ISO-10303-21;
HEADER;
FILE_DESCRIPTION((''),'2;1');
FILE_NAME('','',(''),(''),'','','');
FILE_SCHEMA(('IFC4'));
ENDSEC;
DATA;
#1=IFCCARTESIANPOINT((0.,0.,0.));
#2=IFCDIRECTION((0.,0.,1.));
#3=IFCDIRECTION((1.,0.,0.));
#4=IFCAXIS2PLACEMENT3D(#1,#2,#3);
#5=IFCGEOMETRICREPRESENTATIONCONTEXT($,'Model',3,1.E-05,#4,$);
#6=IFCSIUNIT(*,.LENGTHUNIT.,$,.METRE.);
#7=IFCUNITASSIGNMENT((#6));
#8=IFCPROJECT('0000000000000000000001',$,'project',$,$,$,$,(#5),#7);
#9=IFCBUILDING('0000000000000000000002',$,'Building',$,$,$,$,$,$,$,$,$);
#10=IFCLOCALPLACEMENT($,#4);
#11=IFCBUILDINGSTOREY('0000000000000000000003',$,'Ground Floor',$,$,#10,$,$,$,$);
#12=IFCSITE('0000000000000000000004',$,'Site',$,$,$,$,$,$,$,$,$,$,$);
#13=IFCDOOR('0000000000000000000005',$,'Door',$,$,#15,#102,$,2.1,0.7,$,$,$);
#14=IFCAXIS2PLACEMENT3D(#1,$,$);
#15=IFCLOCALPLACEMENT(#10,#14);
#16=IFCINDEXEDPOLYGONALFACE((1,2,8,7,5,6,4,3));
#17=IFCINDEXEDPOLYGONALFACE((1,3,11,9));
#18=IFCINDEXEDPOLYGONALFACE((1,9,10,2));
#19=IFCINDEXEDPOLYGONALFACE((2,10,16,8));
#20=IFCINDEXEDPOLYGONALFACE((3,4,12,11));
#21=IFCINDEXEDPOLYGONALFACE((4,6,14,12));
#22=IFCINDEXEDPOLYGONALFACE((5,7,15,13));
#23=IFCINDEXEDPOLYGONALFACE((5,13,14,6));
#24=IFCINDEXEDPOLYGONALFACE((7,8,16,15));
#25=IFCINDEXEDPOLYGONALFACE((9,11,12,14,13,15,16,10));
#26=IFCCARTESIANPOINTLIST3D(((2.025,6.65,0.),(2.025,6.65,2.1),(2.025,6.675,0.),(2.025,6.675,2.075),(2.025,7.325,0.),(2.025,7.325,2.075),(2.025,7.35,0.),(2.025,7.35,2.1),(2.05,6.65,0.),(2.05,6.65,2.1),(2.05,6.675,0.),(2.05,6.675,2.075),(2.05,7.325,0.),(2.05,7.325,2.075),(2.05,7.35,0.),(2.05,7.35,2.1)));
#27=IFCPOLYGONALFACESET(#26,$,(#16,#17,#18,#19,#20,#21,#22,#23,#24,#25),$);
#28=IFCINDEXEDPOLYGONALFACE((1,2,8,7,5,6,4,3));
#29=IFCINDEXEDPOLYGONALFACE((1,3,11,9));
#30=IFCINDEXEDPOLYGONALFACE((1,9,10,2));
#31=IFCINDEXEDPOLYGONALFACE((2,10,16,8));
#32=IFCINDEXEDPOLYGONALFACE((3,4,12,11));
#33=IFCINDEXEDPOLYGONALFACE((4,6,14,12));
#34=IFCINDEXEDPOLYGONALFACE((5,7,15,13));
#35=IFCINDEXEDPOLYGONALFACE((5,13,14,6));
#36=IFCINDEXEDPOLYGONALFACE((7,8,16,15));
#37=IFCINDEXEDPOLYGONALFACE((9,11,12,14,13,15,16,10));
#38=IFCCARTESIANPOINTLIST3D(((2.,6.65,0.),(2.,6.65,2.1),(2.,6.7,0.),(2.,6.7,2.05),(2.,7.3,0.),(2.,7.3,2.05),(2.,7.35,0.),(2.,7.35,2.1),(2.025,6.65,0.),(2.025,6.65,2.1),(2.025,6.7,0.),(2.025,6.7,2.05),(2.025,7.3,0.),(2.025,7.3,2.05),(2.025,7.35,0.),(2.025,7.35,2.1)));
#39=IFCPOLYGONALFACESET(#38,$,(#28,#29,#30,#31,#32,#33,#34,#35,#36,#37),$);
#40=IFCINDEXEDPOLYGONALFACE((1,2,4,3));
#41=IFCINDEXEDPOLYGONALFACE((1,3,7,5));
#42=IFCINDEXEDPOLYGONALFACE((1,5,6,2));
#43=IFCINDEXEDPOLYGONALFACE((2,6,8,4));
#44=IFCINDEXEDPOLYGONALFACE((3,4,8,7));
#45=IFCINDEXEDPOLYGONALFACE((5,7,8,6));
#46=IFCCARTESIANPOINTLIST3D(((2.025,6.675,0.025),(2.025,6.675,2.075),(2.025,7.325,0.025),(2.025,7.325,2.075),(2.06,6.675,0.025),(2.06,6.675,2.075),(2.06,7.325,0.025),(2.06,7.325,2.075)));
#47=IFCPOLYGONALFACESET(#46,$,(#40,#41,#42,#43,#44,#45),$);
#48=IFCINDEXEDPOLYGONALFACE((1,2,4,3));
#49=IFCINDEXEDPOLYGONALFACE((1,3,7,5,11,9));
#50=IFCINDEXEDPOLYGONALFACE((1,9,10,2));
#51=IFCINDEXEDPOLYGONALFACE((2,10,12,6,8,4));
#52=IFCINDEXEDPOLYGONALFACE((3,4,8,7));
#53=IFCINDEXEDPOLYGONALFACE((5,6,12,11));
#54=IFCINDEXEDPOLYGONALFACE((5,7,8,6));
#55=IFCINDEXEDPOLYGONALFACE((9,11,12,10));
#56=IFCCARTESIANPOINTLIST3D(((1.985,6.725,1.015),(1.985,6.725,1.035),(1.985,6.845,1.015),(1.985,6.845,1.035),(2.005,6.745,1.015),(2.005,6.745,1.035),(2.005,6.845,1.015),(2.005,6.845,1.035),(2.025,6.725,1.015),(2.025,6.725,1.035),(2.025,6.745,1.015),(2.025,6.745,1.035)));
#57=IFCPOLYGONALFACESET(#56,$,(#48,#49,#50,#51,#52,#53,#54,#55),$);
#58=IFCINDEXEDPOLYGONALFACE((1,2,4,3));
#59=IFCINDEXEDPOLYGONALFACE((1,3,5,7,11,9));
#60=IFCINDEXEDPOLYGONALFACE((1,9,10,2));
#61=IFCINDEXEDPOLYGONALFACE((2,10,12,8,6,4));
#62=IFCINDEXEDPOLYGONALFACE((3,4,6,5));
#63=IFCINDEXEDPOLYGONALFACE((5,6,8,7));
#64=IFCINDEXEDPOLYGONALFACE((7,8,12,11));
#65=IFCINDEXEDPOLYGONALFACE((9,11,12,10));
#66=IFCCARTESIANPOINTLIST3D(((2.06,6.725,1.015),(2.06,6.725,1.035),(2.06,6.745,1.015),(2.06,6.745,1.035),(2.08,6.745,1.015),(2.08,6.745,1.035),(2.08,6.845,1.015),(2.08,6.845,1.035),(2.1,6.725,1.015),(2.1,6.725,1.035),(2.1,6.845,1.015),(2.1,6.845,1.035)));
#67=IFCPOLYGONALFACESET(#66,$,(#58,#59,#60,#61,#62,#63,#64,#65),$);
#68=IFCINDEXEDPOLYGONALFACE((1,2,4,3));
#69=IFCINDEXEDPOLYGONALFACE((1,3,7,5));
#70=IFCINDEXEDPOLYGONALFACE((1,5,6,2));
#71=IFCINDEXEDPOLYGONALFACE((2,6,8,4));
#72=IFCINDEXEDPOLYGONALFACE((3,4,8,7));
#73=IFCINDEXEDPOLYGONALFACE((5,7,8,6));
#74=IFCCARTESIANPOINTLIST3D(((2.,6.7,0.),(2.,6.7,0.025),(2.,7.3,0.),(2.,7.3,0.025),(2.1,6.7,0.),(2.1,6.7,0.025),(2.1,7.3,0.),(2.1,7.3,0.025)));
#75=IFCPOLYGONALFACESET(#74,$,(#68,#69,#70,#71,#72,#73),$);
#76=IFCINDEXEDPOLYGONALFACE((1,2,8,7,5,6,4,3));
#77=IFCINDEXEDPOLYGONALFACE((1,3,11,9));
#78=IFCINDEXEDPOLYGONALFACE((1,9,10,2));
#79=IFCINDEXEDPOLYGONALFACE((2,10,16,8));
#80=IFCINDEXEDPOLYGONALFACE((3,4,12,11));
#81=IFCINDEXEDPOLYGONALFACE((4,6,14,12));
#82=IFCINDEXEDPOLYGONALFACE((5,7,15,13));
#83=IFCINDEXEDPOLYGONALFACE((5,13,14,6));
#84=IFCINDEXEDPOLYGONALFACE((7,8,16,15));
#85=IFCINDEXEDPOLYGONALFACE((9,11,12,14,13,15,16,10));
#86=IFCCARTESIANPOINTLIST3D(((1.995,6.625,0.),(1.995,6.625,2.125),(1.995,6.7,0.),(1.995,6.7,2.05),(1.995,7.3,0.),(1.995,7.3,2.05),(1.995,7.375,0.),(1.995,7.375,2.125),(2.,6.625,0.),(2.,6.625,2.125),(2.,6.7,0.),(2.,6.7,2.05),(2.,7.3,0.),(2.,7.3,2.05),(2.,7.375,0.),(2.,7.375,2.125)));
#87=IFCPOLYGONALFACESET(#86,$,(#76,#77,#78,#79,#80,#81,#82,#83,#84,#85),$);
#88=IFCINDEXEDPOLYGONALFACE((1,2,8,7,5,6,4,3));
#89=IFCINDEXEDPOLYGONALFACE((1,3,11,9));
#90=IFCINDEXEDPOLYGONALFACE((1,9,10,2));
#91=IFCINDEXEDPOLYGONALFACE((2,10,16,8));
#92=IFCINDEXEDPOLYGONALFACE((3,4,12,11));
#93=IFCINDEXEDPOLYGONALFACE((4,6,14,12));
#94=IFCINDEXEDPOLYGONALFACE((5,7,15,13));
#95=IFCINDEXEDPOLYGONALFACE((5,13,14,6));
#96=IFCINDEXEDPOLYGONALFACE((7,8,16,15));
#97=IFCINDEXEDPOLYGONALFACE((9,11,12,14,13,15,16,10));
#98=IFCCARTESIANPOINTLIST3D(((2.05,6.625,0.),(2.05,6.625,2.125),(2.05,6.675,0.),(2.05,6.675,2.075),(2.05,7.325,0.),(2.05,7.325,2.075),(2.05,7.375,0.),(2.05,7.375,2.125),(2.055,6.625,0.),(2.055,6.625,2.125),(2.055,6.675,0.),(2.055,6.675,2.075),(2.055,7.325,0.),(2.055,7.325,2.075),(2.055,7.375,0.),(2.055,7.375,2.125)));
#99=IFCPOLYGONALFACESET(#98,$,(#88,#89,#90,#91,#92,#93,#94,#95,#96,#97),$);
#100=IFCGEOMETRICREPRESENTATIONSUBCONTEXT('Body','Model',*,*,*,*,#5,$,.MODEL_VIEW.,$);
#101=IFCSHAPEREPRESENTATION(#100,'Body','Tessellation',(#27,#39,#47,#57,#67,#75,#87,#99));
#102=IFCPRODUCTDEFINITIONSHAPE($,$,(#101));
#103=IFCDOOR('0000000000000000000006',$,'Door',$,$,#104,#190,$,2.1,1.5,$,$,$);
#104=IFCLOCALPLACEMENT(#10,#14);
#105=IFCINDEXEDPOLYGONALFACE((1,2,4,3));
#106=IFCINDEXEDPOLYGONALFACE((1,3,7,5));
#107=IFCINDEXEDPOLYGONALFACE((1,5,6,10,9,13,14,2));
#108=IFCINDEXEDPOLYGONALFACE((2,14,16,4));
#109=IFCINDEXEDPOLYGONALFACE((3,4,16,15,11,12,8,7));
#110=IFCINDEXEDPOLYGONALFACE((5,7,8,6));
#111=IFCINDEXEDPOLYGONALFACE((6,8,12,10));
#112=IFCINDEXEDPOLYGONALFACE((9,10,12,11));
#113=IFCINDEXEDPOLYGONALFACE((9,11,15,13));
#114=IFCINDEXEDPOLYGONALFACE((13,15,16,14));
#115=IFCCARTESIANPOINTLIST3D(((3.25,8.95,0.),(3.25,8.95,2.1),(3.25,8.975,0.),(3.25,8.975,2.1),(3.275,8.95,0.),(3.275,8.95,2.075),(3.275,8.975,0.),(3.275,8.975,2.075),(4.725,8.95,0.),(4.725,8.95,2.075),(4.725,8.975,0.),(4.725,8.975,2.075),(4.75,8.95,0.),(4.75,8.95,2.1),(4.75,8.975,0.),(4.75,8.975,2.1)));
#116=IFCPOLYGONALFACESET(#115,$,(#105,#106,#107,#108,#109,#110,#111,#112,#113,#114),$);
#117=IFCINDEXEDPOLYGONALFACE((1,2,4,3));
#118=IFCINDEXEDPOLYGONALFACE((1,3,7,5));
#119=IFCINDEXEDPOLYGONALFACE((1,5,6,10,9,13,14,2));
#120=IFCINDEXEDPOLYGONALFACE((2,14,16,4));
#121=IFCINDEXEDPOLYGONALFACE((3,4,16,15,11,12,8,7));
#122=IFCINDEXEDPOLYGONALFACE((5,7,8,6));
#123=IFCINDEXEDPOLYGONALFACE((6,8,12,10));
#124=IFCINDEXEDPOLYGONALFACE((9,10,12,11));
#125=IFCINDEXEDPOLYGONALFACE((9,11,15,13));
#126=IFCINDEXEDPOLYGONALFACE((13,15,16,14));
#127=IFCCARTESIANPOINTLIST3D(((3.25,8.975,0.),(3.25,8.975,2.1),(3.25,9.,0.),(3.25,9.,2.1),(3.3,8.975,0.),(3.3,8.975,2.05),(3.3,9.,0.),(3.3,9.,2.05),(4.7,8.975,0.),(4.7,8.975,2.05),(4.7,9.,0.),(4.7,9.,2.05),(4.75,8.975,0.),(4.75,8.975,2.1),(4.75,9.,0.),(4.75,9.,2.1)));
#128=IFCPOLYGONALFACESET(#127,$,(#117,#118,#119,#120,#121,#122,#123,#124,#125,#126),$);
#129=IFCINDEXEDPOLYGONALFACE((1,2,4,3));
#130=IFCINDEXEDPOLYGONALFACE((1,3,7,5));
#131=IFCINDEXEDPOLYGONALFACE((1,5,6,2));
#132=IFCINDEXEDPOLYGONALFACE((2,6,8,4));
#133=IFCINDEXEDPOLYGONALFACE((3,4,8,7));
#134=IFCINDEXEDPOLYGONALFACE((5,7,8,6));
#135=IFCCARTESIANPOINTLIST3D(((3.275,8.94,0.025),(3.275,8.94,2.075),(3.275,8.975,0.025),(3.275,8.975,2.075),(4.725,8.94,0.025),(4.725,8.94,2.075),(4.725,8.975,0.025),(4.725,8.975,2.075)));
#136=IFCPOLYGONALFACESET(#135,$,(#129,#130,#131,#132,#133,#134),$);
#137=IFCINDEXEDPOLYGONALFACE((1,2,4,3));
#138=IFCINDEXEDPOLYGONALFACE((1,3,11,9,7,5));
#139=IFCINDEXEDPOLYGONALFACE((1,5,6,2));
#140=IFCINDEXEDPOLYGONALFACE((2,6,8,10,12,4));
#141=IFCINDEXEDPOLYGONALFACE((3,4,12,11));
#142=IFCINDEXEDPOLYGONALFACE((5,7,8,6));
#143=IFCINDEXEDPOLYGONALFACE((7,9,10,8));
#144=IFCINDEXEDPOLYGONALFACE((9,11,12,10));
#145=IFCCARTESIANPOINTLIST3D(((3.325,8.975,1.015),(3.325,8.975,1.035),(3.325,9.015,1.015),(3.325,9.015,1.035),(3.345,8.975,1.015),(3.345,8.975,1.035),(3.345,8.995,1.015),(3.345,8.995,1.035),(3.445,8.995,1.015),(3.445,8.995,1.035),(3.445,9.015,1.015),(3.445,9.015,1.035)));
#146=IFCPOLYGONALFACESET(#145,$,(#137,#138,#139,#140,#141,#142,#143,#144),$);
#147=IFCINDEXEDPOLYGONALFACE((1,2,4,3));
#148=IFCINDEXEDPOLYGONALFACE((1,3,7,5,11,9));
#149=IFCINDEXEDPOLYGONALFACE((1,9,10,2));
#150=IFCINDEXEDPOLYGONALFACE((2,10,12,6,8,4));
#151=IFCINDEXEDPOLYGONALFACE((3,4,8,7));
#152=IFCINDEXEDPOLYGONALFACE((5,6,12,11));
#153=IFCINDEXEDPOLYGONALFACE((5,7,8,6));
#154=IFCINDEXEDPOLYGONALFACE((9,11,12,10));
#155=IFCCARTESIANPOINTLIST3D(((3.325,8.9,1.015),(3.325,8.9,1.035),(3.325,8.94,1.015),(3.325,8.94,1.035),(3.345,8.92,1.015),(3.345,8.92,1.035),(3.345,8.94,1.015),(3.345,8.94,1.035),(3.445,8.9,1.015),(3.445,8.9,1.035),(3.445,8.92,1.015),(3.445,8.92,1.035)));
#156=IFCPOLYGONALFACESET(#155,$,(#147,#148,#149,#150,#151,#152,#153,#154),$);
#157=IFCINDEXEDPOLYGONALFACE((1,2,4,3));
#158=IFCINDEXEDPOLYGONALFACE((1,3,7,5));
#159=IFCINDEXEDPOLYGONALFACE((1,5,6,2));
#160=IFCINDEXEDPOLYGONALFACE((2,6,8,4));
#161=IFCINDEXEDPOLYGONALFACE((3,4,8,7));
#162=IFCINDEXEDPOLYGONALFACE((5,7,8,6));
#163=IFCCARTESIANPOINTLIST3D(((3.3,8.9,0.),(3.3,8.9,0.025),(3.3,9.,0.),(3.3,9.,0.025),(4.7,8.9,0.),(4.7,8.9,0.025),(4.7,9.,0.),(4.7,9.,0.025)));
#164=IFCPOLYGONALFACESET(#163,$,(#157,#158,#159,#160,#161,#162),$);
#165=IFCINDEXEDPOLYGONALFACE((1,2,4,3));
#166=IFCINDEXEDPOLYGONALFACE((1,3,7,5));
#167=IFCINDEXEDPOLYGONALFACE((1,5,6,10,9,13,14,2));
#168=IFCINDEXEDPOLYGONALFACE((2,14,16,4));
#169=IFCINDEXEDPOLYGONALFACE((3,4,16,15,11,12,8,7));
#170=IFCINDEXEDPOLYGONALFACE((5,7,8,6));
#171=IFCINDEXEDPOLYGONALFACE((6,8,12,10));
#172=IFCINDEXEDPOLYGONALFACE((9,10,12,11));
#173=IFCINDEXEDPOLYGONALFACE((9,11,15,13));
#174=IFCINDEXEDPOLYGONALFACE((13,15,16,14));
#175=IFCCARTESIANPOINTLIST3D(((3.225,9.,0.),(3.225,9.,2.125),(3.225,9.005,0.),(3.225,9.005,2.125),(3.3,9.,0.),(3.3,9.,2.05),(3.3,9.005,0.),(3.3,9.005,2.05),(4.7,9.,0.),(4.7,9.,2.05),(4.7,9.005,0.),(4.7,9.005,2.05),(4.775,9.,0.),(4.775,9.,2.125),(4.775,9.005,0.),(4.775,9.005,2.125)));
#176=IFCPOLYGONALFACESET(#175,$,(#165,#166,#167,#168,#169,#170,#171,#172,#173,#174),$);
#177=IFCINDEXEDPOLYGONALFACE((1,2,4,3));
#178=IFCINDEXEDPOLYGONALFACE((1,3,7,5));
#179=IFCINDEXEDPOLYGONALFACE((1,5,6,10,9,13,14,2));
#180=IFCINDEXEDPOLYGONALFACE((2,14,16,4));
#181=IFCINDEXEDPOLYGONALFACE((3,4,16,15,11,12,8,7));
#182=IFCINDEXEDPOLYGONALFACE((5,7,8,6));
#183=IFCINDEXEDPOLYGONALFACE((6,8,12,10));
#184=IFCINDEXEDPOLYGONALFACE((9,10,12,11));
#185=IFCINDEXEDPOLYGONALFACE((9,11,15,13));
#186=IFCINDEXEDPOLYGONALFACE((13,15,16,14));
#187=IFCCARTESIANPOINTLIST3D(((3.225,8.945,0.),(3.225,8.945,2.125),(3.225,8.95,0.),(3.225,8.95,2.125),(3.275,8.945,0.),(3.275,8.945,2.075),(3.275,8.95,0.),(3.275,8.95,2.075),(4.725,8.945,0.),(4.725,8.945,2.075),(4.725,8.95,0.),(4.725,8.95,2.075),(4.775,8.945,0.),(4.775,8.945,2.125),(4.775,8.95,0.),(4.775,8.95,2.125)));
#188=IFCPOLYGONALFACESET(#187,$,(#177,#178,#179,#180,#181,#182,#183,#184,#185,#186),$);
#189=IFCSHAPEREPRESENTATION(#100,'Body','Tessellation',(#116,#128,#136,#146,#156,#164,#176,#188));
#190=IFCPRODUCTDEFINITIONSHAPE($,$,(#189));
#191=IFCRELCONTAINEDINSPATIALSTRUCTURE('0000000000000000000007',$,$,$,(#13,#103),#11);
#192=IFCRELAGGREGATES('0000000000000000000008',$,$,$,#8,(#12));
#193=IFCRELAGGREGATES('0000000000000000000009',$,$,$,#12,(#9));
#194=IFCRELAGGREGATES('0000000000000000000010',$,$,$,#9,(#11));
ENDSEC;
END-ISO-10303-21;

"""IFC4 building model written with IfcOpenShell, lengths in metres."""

from ifc_helpers import new_model, si_unit, frame, origin_with_axes, place, context, subcontext, project, spatial, line, indexed_curve, outline, extrude, element, save


model = new_model("IFC4")

# Units and contexts
model_context = context("Model", 3, precision=1e-05, world=origin_with_axes())
body_context = subcontext(model_context, "Body", "Model", "MODEL_VIEW")
ifc_project = project(units=[si_unit("LENGTHUNIT", "METRE")], contexts=[model_context])

# Site, building, storey
site = spatial("IfcSite", under=ifc_project, Name="Site")
building = spatial("IfcBuilding", under=site, Name="Building")
storey_placement = place(None, origin_with_axes())
storey = spatial("IfcBuildingStorey", under=building, at=storey_placement, Name="Ground Floor")

# Doors
door_1_placement = place(storey_placement, frame((2.0, 7.35, 0.0), z_axis=(0.0, 0.0, 1.0), x_axis=(0.0, -1.0, 0.0)))
element("IfcDoor", 1, at=door_1_placement, inside=storey, Name="Door", OverallHeight=2.1, OverallWidth=0.7, context=body_context, shape_type="SweptSolid", body=[
    extrude(outline(indexed_curve([(0.0, 0.0), (0.0, 2.1), (0.7, 2.1), (0.7, 0.0), (0.675, 0.0), (0.675, 2.075), (0.025, 2.075), (0.025, 0.0)], segments=[line(1, 2, 3, 4, 5, 6, 7, 8, 1)])), frame((0.0, 0.025, 0.0), z_axis=(0.0, -1.0, 0.0), x_axis=(1.0, 0.0, 0.0)), (0.0, 0.0, -1.0), 0.025),
    extrude(outline(indexed_curve([(0.0, 0.0), (0.0, 2.1), (0.7, 2.1), (0.7, 0.0), (0.65, 0.0), (0.65, 2.05), (0.05, 2.05), (0.05, 0.0)], segments=[line(1, 2, 3, 4, 5, 6, 7, 8, 1)])), frame((0.0, 0.0, 0.0), z_axis=(0.0, -1.0, 0.0), x_axis=(1.0, 0.0, 0.0)), (0.0, 0.0, -1.0), 0.025),
    extrude(outline(indexed_curve([(0.0, 0.0), (0.65, 0.0), (0.65, 0.035), (0.0, 0.035)], segments=[line(1, 2, 3, 4, 1)])), frame((0.025, 0.025, 0.025), z_axis=(0.0, 0.0, 1.0), x_axis=(1.0, 0.0, 0.0)), (0.0, 0.0, 1.0), 2.05),
    extrude(outline(indexed_curve([(0.0, 0.0), (0.0, -0.04), (-0.12, -0.04), (-0.12, -0.02), (-0.02, -0.02), (-0.02, 0.0)], segments=[line(1, 2, 3, 4, 5, 6, 1)])), frame((0.625, 0.025, 1.015), z_axis=(0.0, 0.0, 1.0), x_axis=(1.0, 0.0, 0.0)), (0.0, 0.0, 1.0), 0.02),
    extrude(outline(indexed_curve([(0.0, 0.0), (0.0, 0.04), (-0.12, 0.04), (-0.12, 0.02), (-0.02, 0.02), (-0.02, 0.0)], segments=[line(1, 2, 3, 4, 5, 6, 1)])), frame((0.625, 0.06, 1.015), z_axis=(0.0, 0.0, 1.0), x_axis=(1.0, 0.0, 0.0)), (0.0, 0.0, 1.0), 0.02),
    extrude(outline(indexed_curve([(0.0, 0.0), (0.6, 0.0), (0.6, 0.1), (0.0, 0.1)], segments=[line(1, 2, 3, 4, 1)])), frame((0.05, 0.0, 0.0), z_axis=(0.0, 0.0, 1.0), x_axis=(1.0, 0.0, 0.0)), (0.0, 0.0, 1.0), 0.025),
    extrude(outline(indexed_curve([(0.0, 0.0), (0.0, 2.125), (0.75, 2.125), (0.75, 0.0), (0.675, 0.0), (0.675, 2.05), (0.075, 2.05), (0.075, 0.0)], segments=[line(1, 2, 3, 4, 5, 6, 7, 8, 1)])), frame((-0.025, -0.005, 0.0), z_axis=(0.0, -1.0, 0.0), x_axis=(1.0, 0.0, 0.0)), (0.0, 0.0, -1.0), 0.005),
    extrude(outline(indexed_curve([(0.0, 0.0), (0.0, 2.125), (0.75, 2.125), (0.75, 0.0), (0.7, 0.0), (0.7, 2.075), (0.05, 2.075), (0.05, 0.0)], segments=[line(1, 2, 3, 4, 5, 6, 7, 8, 1)])), frame((-0.025, 0.05, 0.0), z_axis=(0.0, -1.0, 0.0), x_axis=(1.0, 0.0, 0.0)), (0.0, 0.0, -1.0), 0.005),
])
door_2_placement = place(storey_placement, frame((4.75, 9.0, 0.0), z_axis=(0.0, 0.0, 1.0), x_axis=(-1.0, 0.0, 0.0)))
element("IfcDoor", 2, at=door_2_placement, inside=storey, Name="Door", OverallHeight=2.1, OverallWidth=1.5, context=body_context, shape_type="SweptSolid", body=[
    extrude(outline(indexed_curve([(0.0, 0.0), (0.0, 2.1), (1.5, 2.1), (1.5, 0.0), (1.475, 0.0), (1.475, 2.075), (0.025, 2.075), (0.025, 0.0)], segments=[line(1, 2, 3, 4, 5, 6, 7, 8, 1)])), frame((0.0, 0.025, 0.0), z_axis=(0.0, -1.0, 0.0), x_axis=(1.0, 0.0, 0.0)), (0.0, 0.0, -1.0), 0.025),
    extrude(outline(indexed_curve([(0.0, 0.0), (0.0, 2.1), (1.5, 2.1), (1.5, 0.0), (1.45, 0.0), (1.45, 2.05), (0.05, 2.05), (0.05, 0.0)], segments=[line(1, 2, 3, 4, 5, 6, 7, 8, 1)])), frame((0.0, 0.0, 0.0), z_axis=(0.0, -1.0, 0.0), x_axis=(1.0, 0.0, 0.0)), (0.0, 0.0, -1.0), 0.025),
    extrude(outline(indexed_curve([(0.0, 0.0), (1.45, 0.0), (1.45, 0.035), (0.0, 0.035)], segments=[line(1, 2, 3, 4, 1)])), frame((0.025, 0.025, 0.025), z_axis=(0.0, 0.0, 1.0), x_axis=(1.0, 0.0, 0.0)), (0.0, 0.0, 1.0), 2.05),
    extrude(outline(indexed_curve([(0.0, 0.0), (0.0, -0.04), (-0.12, -0.04), (-0.12, -0.02), (-0.02, -0.02), (-0.02, 0.0)], segments=[line(1, 2, 3, 4, 5, 6, 1)])), frame((1.425, 0.025, 1.015), z_axis=(0.0, 0.0, 1.0), x_axis=(1.0, 0.0, 0.0)), (0.0, 0.0, 1.0), 0.02),
    extrude(outline(indexed_curve([(0.0, 0.0), (0.0, 0.04), (-0.12, 0.04), (-0.12, 0.02), (-0.02, 0.02), (-0.02, 0.0)], segments=[line(1, 2, 3, 4, 5, 6, 1)])), frame((1.425, 0.06, 1.015), z_axis=(0.0, 0.0, 1.0), x_axis=(1.0, 0.0, 0.0)), (0.0, 0.0, 1.0), 0.02),
    extrude(outline(indexed_curve([(0.0, 0.0), (1.4, 0.0), (1.4, 0.1), (0.0, 0.1)], segments=[line(1, 2, 3, 4, 1)])), frame((0.05, 0.0, 0.0), z_axis=(0.0, 0.0, 1.0), x_axis=(1.0, 0.0, 0.0)), (0.0, 0.0, 1.0), 0.025),
    extrude(outline(indexed_curve([(0.0, 0.0), (0.0, 2.125), (1.55, 2.125), (1.55, 0.0), (1.475, 0.0), (1.475, 2.05), (0.075, 2.05), (0.075, 0.0)], segments=[line(1, 2, 3, 4, 5, 6, 7, 8, 1)])), frame((-0.025, -0.005, 0.0), z_axis=(0.0, -1.0, 0.0), x_axis=(1.0, 0.0, 0.0)), (0.0, 0.0, -1.0), 0.005),
    extrude(outline(indexed_curve([(0.0, 0.0), (0.0, 2.125), (1.55, 2.125), (1.55, 0.0), (1.5, 0.0), (1.5, 2.075), (0.05, 2.075), (0.05, 0.0)], segments=[line(1, 2, 3, 4, 5, 6, 7, 8, 1)])), frame((-0.025, 0.05, 0.0), z_axis=(0.0, -1.0, 0.0), x_axis=(1.0, 0.0, 0.0)), (0.0, 0.0, -1.0), 0.005),
])

save(model, "model.ifc")
